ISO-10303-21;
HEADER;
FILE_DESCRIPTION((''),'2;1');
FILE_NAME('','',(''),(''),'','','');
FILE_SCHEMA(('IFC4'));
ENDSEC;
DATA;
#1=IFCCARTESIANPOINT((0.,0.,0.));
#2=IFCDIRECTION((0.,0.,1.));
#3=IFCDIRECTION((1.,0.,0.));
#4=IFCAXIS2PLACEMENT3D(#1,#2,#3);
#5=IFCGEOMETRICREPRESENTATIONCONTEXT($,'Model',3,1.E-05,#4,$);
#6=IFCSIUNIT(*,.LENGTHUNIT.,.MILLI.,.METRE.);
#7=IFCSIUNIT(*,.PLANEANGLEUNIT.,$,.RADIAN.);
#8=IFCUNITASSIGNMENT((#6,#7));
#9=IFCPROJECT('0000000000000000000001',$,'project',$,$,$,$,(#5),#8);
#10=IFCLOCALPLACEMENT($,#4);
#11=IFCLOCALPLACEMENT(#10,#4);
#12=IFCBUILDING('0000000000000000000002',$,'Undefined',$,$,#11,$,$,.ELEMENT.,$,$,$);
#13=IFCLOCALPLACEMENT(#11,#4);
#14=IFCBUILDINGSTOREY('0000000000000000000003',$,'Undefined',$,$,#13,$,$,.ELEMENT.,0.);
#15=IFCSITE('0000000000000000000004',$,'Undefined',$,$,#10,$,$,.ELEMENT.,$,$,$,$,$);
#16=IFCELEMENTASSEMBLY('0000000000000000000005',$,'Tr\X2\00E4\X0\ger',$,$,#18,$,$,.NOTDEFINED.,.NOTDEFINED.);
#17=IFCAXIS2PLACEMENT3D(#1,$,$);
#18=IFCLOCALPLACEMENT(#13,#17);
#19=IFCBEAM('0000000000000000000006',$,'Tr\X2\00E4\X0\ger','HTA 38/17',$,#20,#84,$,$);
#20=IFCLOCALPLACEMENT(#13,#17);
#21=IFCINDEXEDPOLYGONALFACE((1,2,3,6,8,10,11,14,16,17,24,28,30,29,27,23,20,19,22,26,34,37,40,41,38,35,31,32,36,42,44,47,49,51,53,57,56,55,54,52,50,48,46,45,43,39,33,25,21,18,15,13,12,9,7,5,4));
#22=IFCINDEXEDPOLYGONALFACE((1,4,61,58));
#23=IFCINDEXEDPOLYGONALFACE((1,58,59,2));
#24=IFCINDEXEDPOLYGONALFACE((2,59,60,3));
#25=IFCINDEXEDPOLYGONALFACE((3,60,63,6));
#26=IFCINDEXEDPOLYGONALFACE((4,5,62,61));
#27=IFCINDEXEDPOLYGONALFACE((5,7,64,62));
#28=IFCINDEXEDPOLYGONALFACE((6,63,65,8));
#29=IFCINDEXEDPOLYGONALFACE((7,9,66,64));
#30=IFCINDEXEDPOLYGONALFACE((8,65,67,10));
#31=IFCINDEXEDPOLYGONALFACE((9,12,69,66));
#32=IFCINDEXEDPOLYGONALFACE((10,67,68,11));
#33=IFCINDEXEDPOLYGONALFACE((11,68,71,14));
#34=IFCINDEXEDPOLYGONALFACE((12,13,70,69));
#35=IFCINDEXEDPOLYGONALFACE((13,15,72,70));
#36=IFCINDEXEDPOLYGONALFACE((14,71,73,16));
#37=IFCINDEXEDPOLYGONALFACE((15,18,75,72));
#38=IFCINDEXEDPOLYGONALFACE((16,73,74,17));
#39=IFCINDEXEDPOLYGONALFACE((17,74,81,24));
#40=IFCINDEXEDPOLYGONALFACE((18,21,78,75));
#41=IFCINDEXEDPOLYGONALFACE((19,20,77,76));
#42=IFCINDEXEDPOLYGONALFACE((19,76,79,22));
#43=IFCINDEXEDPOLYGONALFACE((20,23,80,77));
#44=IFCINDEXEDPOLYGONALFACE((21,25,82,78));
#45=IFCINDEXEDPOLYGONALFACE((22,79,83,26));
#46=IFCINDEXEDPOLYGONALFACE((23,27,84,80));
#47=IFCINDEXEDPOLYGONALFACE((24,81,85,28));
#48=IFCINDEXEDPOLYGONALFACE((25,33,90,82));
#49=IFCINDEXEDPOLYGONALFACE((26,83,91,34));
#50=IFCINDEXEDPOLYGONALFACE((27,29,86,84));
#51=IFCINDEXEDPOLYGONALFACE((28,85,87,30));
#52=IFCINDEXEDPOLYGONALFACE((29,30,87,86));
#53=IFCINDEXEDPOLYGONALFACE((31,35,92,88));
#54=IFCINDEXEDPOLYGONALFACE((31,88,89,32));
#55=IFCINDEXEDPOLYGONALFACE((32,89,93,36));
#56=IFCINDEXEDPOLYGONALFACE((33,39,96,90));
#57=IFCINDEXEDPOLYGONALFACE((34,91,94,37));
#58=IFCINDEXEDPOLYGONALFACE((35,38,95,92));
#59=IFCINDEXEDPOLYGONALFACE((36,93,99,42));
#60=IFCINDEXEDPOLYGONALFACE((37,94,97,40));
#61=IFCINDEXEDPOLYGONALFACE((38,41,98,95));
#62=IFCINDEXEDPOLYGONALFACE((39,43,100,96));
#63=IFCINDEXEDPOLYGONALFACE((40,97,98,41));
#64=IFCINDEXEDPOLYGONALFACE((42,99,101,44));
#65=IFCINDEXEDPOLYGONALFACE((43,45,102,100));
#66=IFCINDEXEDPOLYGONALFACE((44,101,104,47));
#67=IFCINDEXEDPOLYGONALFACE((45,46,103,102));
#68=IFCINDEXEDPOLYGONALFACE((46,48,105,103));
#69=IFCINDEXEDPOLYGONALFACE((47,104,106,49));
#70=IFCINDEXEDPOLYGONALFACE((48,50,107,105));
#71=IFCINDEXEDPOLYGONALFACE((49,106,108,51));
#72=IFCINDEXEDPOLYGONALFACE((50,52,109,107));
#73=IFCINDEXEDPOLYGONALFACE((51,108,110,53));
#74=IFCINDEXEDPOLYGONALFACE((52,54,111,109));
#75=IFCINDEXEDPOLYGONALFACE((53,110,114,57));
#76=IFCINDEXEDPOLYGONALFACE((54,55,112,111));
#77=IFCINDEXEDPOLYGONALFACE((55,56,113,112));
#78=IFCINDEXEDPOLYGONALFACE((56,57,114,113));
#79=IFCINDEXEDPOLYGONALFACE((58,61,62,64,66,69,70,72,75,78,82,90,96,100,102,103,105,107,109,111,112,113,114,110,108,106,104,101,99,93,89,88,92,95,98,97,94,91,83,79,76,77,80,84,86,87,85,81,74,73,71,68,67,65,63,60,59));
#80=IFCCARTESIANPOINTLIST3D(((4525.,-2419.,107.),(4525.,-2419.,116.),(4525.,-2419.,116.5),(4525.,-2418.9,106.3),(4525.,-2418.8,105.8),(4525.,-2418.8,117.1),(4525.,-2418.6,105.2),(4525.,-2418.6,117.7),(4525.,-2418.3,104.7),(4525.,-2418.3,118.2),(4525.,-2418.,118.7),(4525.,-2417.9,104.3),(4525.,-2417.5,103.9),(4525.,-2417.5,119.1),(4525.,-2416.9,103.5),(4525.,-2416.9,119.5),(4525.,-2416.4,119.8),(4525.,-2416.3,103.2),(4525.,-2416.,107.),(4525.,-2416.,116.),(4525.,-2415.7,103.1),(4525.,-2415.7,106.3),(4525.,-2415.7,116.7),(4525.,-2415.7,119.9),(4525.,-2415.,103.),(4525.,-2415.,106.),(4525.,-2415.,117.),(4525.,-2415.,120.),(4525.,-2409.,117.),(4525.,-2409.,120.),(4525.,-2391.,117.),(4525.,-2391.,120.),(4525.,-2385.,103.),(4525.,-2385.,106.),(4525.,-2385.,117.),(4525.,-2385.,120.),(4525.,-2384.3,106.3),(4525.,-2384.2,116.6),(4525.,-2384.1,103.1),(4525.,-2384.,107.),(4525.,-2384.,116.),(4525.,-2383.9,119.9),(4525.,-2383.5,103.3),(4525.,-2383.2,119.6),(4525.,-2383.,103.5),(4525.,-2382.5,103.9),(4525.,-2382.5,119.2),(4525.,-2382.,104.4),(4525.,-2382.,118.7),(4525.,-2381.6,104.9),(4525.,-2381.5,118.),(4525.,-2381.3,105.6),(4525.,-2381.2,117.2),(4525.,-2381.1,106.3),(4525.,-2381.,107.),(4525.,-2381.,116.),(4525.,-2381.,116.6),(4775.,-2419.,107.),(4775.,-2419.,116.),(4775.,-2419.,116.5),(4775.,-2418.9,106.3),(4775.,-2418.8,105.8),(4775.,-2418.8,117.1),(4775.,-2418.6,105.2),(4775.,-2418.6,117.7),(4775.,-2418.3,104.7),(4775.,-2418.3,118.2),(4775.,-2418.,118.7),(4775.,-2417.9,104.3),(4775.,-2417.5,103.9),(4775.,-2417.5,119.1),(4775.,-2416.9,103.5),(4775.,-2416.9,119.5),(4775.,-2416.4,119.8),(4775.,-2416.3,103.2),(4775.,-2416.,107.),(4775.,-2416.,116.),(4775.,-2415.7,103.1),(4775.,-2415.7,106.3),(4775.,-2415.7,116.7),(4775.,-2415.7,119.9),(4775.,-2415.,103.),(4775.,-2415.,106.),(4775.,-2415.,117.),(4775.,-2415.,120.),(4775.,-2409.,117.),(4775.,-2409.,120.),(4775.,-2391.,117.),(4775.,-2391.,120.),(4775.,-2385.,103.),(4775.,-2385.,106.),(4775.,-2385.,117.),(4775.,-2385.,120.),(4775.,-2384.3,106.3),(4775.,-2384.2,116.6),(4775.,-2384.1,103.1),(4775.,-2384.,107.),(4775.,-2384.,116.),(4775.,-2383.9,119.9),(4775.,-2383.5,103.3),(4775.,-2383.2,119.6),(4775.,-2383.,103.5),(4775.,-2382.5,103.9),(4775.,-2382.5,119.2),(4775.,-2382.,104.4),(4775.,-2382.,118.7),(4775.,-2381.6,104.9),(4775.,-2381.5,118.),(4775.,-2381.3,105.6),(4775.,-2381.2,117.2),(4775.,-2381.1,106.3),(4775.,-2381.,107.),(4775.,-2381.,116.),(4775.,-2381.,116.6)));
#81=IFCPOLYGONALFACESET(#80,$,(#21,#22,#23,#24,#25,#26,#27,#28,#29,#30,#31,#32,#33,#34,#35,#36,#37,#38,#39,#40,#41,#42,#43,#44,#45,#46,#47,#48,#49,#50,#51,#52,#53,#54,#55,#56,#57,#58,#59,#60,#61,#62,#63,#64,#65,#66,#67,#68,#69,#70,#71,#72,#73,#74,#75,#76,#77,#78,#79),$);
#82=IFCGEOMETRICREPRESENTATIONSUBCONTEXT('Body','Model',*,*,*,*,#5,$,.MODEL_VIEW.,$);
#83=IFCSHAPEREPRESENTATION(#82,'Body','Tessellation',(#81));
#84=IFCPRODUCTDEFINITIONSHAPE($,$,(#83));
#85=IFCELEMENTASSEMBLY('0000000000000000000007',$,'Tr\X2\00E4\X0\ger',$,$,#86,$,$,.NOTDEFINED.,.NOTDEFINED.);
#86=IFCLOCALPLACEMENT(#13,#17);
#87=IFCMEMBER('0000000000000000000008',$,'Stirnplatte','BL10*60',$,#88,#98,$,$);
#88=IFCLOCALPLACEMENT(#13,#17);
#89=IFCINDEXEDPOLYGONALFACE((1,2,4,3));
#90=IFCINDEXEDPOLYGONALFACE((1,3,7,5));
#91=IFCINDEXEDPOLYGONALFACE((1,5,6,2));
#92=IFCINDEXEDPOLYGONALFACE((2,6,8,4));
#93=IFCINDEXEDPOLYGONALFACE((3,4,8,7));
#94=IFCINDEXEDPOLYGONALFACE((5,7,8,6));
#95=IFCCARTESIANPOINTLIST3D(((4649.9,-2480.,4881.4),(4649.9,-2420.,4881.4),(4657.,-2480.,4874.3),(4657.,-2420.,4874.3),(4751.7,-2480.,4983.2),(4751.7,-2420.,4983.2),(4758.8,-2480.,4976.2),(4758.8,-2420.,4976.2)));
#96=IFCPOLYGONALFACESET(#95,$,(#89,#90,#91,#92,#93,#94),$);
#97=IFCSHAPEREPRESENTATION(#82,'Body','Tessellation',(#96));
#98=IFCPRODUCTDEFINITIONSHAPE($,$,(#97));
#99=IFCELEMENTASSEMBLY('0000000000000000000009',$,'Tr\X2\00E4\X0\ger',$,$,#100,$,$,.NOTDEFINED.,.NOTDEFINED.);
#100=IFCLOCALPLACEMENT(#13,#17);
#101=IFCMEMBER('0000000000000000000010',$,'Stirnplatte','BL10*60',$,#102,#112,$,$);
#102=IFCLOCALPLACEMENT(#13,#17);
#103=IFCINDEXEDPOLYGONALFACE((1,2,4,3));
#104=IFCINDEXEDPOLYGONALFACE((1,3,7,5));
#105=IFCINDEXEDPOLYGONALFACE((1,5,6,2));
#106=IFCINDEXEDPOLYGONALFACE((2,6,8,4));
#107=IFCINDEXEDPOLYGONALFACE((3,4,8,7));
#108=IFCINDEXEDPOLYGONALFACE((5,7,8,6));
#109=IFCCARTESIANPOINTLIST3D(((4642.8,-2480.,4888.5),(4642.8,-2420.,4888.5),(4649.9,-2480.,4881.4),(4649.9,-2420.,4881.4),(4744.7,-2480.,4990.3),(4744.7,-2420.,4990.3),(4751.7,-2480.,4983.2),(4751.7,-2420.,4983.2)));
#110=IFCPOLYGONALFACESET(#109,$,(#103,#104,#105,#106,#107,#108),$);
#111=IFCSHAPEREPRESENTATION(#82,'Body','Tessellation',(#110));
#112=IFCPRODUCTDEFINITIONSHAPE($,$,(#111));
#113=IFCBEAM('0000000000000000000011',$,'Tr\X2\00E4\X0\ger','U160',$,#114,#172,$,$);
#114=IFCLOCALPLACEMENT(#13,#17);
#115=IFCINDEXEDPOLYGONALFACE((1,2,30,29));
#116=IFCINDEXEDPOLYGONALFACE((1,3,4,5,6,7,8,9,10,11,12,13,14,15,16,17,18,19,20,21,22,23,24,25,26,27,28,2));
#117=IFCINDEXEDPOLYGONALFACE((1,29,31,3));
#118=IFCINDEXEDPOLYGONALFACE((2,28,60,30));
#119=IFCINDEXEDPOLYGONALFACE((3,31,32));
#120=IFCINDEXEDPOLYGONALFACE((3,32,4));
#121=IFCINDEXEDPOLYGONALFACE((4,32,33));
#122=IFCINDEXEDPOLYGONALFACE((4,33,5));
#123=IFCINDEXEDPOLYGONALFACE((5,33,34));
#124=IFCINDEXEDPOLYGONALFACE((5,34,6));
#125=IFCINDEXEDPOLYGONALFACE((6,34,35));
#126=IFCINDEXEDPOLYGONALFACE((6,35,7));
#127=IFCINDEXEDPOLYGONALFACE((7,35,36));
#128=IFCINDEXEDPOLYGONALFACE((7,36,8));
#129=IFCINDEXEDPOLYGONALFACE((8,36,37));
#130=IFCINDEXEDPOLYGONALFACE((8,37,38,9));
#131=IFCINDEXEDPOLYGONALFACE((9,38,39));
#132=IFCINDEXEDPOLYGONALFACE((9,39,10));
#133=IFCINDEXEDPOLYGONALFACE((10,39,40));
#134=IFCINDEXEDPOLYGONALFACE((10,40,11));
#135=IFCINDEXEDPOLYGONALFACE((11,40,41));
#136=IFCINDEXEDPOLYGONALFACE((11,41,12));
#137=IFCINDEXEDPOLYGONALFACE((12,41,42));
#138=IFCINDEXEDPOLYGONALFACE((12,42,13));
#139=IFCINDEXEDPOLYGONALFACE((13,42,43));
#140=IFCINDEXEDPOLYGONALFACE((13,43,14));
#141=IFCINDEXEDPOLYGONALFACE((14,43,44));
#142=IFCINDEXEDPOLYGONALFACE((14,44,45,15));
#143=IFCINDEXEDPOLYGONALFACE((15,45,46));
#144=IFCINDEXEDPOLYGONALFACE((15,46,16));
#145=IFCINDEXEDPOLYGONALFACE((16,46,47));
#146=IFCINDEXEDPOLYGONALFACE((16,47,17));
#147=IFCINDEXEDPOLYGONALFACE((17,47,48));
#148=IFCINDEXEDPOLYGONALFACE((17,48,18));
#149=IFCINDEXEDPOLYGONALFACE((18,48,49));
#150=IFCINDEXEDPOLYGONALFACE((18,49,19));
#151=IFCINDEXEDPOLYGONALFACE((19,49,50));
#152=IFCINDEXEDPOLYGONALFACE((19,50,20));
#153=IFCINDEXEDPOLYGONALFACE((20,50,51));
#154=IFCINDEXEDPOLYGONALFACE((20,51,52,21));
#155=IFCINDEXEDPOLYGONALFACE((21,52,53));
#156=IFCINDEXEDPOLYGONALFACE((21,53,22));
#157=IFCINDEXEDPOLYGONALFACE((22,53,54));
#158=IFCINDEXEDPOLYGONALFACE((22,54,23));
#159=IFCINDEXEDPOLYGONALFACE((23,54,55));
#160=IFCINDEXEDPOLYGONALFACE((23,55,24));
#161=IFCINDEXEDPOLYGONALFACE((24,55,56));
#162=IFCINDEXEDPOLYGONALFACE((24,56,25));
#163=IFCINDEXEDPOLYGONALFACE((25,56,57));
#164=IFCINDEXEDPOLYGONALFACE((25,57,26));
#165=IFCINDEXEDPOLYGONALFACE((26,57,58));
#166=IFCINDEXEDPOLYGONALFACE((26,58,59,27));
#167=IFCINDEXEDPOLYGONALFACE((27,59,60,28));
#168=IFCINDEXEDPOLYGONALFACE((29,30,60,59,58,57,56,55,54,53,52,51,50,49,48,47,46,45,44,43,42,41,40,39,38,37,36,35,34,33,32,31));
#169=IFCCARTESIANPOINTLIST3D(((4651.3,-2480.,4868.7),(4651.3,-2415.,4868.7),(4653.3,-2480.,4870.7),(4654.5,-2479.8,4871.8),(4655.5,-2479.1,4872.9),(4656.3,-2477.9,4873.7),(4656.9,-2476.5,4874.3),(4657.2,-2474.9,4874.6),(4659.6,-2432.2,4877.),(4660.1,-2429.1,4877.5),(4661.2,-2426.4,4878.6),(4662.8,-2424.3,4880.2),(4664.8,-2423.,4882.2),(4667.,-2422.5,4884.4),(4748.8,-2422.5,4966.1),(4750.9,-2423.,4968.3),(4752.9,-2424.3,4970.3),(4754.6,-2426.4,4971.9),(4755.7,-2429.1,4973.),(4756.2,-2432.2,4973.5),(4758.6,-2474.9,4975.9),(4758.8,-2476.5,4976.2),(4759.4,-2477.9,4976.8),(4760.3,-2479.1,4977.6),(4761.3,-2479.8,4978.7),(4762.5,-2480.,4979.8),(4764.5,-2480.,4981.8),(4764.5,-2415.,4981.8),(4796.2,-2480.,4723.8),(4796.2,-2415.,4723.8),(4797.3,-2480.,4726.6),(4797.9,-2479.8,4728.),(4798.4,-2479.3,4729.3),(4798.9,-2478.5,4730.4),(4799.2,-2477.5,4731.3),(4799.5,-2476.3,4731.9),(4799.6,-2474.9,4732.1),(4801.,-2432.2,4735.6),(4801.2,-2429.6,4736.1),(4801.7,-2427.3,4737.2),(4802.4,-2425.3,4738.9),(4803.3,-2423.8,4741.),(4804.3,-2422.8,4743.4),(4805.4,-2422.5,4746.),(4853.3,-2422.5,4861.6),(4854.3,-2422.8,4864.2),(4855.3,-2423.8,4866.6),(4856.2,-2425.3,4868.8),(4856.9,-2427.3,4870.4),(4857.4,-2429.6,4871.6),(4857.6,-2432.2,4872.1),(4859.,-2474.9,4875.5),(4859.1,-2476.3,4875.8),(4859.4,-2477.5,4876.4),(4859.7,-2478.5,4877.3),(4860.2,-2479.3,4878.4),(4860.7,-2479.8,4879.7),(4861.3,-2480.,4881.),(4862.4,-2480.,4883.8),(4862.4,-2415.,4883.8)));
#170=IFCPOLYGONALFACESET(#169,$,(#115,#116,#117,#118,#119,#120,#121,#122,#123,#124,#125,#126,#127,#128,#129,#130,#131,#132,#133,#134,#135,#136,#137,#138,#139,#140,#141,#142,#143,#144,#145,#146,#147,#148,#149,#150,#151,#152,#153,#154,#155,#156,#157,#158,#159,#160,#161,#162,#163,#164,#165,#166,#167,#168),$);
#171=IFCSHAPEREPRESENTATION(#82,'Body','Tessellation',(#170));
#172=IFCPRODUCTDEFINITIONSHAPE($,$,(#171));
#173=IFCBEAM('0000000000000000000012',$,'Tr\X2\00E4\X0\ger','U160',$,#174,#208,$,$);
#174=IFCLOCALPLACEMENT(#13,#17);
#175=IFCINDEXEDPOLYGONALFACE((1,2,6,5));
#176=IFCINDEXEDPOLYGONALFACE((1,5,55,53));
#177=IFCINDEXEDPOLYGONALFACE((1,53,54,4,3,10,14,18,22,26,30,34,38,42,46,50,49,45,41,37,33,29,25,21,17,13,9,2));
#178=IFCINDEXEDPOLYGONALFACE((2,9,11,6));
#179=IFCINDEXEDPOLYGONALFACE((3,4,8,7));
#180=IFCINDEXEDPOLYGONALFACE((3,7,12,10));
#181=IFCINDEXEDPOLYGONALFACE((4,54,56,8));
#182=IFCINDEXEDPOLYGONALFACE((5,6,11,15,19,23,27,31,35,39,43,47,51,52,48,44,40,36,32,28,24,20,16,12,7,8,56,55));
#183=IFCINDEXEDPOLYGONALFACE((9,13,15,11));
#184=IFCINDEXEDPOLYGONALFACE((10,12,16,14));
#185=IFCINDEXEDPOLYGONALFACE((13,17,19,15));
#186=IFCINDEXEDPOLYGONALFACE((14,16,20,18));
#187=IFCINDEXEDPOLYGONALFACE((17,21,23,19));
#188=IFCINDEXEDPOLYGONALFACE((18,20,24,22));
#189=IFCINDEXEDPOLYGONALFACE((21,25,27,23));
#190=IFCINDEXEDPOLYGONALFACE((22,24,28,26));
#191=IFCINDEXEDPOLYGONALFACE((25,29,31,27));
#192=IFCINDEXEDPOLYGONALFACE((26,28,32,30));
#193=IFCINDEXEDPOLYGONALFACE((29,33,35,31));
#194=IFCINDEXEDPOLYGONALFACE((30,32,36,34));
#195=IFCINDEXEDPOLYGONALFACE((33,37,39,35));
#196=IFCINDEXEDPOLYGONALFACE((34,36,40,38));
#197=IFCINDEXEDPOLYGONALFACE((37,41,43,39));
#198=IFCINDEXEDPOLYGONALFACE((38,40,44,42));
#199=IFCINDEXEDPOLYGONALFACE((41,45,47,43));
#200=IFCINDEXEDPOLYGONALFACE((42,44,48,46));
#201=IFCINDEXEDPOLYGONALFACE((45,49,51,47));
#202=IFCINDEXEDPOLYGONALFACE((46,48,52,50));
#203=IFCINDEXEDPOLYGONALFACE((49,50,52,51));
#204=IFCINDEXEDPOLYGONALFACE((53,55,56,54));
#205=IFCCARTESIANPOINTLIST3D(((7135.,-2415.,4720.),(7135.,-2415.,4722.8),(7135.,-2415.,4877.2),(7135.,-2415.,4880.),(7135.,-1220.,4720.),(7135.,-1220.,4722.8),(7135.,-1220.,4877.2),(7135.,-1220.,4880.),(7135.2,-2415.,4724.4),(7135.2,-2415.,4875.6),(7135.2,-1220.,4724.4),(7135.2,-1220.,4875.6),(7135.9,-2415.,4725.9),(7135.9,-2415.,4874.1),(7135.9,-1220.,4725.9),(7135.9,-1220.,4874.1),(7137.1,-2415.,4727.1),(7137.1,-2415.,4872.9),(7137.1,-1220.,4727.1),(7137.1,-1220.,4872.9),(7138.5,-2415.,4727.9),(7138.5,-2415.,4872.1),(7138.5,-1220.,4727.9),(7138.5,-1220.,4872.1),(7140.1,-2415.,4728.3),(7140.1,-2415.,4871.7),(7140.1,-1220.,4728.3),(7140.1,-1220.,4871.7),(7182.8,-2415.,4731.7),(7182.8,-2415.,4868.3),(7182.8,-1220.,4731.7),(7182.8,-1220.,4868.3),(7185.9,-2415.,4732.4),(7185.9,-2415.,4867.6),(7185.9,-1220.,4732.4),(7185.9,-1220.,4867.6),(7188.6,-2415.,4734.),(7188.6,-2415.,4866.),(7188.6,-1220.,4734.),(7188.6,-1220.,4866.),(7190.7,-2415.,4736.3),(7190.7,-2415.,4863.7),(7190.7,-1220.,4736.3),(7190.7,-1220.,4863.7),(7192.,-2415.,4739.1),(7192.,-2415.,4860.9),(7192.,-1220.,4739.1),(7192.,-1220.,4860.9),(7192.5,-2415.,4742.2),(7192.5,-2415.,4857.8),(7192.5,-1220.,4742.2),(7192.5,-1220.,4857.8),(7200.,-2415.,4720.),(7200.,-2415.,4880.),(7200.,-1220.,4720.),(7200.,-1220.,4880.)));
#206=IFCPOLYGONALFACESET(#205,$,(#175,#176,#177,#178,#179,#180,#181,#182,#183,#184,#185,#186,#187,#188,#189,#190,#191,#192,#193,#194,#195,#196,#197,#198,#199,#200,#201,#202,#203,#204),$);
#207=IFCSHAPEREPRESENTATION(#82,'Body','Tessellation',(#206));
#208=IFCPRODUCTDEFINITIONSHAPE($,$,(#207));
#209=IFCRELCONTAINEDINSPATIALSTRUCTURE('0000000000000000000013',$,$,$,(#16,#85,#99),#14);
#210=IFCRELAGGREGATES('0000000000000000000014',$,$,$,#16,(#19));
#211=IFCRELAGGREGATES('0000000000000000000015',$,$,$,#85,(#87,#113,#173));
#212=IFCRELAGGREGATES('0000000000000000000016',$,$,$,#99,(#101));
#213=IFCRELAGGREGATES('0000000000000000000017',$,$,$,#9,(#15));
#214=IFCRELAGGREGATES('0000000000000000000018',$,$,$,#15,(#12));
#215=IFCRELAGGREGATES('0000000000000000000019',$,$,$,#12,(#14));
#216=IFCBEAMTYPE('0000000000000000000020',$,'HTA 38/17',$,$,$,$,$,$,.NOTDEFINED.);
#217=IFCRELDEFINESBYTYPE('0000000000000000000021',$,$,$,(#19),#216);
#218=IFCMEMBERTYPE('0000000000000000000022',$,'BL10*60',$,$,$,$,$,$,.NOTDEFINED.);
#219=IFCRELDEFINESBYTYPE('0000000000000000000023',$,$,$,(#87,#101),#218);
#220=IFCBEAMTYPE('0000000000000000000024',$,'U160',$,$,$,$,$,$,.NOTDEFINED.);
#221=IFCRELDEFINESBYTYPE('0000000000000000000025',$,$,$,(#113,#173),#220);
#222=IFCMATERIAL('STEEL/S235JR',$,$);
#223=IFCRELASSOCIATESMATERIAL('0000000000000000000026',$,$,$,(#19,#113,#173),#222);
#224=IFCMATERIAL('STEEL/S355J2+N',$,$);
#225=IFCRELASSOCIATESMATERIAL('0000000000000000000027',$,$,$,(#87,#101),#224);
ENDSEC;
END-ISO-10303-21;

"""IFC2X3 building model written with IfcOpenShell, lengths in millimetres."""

from ifc_helpers import new_model, si_unit, frame, origin_with_axes, origin_2d_with_axis, place, context, subcontext, project, spatial, polyline, rectangle, u_section, outline, extrude, clip, halfspace, material, type_object, element, aggregate, save


model = new_model("IFC2X3")

# Units and contexts
model_context = context("Model", 3, precision=1e-05, world=origin_with_axes())
body_context = subcontext(model_context, "Body", "Model", "MODEL_VIEW")
ifc_project = project(units=[si_unit("LENGTHUNIT", "METRE", prefix="MILLI"), si_unit("PLANEANGLEUNIT", "RADIAN")], contexts=[model_context])

# Site, building, storey
site_placement = place(None, origin_with_axes())
site = spatial("IfcSite", under=ifc_project, at=site_placement, Name="Undefined", CompositionType="ELEMENT")
building_placement = place(site_placement, origin_with_axes())
building = spatial("IfcBuilding", under=site, at=building_placement, Name="Undefined", CompositionType="ELEMENT")
storey_placement = place(building_placement, origin_with_axes())
storey = spatial("IfcBuildingStorey", under=building, at=storey_placement, Name="Undefined", CompositionType="ELEMENT", Elevation=0.0)

# Element assembly, beam
assembly_1_placement = place(storey_placement, origin_with_axes())
assembly_1 = element("IfcElementAssembly", 1, at=assembly_1_placement, inside=storey, Name="Träger", AssemblyPlace="NOTDEFINED", PredefinedType="NOTDEFINED")
ifc_material_1 = material(Name="STEEL/S235JR")
beam_type_1 = type_object("IfcBeamType", Name="HTA 38/17", PredefinedType="NOTDEFINED")
beam_1_placement = place(assembly_1_placement, frame((4775.0, -2400.0, 111.5), z_axis=(0.0, 0.0, -1.0), x_axis=(-1.0, 0.0, 0.0)))
beam_1 = element("IfcBeam", 2, at=beam_1_placement, type_object=beam_type_1, material=ifc_material_1, Name="Träger", Description="HTA 38/17", context=body_context, shape_type="SweptSolid", body=[
    extrude(outline(polyline([(19.0, -4.5), (19.0, -5.0), (18.9, -5.6), (18.6, -6.2), (18.3, -6.7), (18.0, -7.2), (17.5, -7.6), (16.9, -8.0), (16.4, -8.3), (15.7, -8.4), (15.0, -8.5), (9.0, -8.5), (9.0, -5.5), (15.0, -5.5), (15.7, -5.2), (16.0, -4.5), (16.0, 4.5), (15.7, 5.2), (15.0, 5.5), (-15.0, 5.5), (-15.7, 5.2), (-16.0, 4.5), (-16.0, -4.5), (-15.8, -5.1), (-15.0, -5.5), (-9.0, -5.5), (-9.0, -8.5), (-15.0, -8.5), (-16.1, -8.4), (-16.8, -8.1), (-17.5, -7.7), (-18.0, -7.2), (-18.5, -6.5), (-18.8, -5.7), (-19.0, -5.1), (-19.0, -4.5), (-19.0, 4.5), (-18.9, 5.2), (-18.7, 5.9), (-18.4, 6.6), (-18.0, 7.1), (-17.5, 7.6), (-17.0, 8.0), (-16.5, 8.2), (-15.9, 8.4), (-15.0, 8.5), (15.0, 8.5), (15.7, 8.4), (16.3, 8.3), (16.9, 8.0), (17.5, 7.6), (17.9, 7.2), (18.3, 6.8), (18.6, 6.3), (18.8, 5.7), (19.0, 5.2), (19.0, 4.5), (19.0, -4.5)])), frame((250.0, 0.0, 0.0), z_axis=(-1.0, 0.0, 0.0), x_axis=(0.0, -1.0, 0.0)), (0.0, 0.0, 1.0), 250.0),
])
aggregate(assembly_1, [beam_1])

# Element assemblies, members
assembly_2_placement = place(storey_placement, origin_with_axes())
assembly_2 = element("IfcElementAssembly", 3, at=assembly_2_placement, inside=storey, Name="Träger", AssemblyPlace="NOTDEFINED", PredefinedType="NOTDEFINED")
ifc_material_2 = material(Name="STEEL/S355J2+N")
member_type = type_object("IfcMemberType", Name="BL10*60", PredefinedType="NOTDEFINED")
member_1_placement = place(assembly_2_placement, frame((4653.4, -2450.0, 4877.9), z_axis=(0.0, -1.0, 0.0), x_axis=(0.707107, 0.0, 0.707107)))
member_1 = element("IfcMember", 4, at=member_1_placement, type_object=member_type, material=ifc_material_2, Name="Stirnplatte", Description="BL10*60", context=body_context, shape_type="SweptSolid", body=[
    extrude(rectangle(XDim=10.0, YDim=60.0, at=origin_2d_with_axis()), frame((144.0, 0.0, 0.0), z_axis=(-1.0, 0.0, 0.0), x_axis=(0.0, -1.0, 0.0)), (0.0, 0.0, 1.0), 144.0),
])
assembly_3_placement = place(storey_placement, origin_with_axes())
assembly_3 = element("IfcElementAssembly", 5, at=assembly_3_placement, inside=storey, Name="Träger", AssemblyPlace="NOTDEFINED", PredefinedType="NOTDEFINED")
member_2_placement = place(assembly_3_placement, frame((4646.4, -2450.0, 4884.9), z_axis=(0.0, -1.0, 0.0), x_axis=(0.707107, 0.0, 0.707107)))
member_2 = element("IfcMember", 6, at=member_2_placement, type_object=member_type, material=ifc_material_2, Name="Stirnplatte", Description="BL10*60", context=body_context, shape_type="SweptSolid", body=[
    extrude(rectangle(XDim=10.0, YDim=60.0, at=origin_2d_with_axis()), frame((144.0, 0.0, 0.0), z_axis=(-1.0, 0.0, 0.0), x_axis=(0.0, -1.0, 0.0)), (0.0, 0.0, 1.0), 144.0),
])

# Beams
beam_type_2 = type_object("IfcBeamType", Name="U160", PredefinedType="NOTDEFINED")
beam_2_placement = place(assembly_2_placement, frame((4700.8, -2447.5, 4932.3), z_axis=(0.707107, 0.0, 0.707107), x_axis=(0.707107, 0.0, -0.707107)))
beam_2 = element("IfcBeam", 7, at=beam_2_placement, type_object=beam_type_2, material=ifc_material_1, Name="Träger", Description="U160", context=body_context, shape_type="Clipping", body=[
    clip(clip(extrude(u_section(Depth=160.0, FlangeWidth=65.0, WebThickness=7.5, FlangeThickness=10.5, FilletRadius=10.5, EdgeRadius=5.5, FlangeSlope=0.07983, at=origin_2d_with_axis()), frame((343.3, 0.0, 0.0), z_axis=(-1.0, 0.0, 0.0), x_axis=(0.0, -1.0, 0.0)), (0.0, 0.0, 1.0), 494.9), halfspace(frame((149.4, 0.0, 78.1), z_axis=(0.92388, 0.0, 0.382683), x_axis=(0.0, 1.0, 0.0)), False)), halfspace(frame((10.0, 0.0, -80.0), z_axis=(1.0, 0.0, 0.0), x_axis=(0.0, -1.0, 0.0)), True)),
])
beam_3_placement = place(assembly_2_placement, frame((7167.5, -1220.0, 4800.0), z_axis=(0.0, 0.0, 1.0), x_axis=(0.0, -1.0, 0.0)))
beam_3 = element("IfcBeam", 8, at=beam_3_placement, type_object=beam_type_2, material=ifc_material_1, Name="Träger", Description="U160", context=body_context, shape_type="SweptSolid", body=[
    extrude(u_section(Depth=160.0, FlangeWidth=65.0, WebThickness=7.5, FlangeThickness=10.5, FilletRadius=10.5, EdgeRadius=5.5, FlangeSlope=0.07983, at=origin_2d_with_axis()), frame((1195.0, 0.0, 0.0), z_axis=(-1.0, 0.0, 0.0), x_axis=(0.0, -1.0, 0.0)), (0.0, 0.0, 1.0), 1195.0),
])

aggregate(assembly_2, [member_1, beam_2, beam_3])

aggregate(assembly_3, [member_2])

save(model, "model.ifc")
